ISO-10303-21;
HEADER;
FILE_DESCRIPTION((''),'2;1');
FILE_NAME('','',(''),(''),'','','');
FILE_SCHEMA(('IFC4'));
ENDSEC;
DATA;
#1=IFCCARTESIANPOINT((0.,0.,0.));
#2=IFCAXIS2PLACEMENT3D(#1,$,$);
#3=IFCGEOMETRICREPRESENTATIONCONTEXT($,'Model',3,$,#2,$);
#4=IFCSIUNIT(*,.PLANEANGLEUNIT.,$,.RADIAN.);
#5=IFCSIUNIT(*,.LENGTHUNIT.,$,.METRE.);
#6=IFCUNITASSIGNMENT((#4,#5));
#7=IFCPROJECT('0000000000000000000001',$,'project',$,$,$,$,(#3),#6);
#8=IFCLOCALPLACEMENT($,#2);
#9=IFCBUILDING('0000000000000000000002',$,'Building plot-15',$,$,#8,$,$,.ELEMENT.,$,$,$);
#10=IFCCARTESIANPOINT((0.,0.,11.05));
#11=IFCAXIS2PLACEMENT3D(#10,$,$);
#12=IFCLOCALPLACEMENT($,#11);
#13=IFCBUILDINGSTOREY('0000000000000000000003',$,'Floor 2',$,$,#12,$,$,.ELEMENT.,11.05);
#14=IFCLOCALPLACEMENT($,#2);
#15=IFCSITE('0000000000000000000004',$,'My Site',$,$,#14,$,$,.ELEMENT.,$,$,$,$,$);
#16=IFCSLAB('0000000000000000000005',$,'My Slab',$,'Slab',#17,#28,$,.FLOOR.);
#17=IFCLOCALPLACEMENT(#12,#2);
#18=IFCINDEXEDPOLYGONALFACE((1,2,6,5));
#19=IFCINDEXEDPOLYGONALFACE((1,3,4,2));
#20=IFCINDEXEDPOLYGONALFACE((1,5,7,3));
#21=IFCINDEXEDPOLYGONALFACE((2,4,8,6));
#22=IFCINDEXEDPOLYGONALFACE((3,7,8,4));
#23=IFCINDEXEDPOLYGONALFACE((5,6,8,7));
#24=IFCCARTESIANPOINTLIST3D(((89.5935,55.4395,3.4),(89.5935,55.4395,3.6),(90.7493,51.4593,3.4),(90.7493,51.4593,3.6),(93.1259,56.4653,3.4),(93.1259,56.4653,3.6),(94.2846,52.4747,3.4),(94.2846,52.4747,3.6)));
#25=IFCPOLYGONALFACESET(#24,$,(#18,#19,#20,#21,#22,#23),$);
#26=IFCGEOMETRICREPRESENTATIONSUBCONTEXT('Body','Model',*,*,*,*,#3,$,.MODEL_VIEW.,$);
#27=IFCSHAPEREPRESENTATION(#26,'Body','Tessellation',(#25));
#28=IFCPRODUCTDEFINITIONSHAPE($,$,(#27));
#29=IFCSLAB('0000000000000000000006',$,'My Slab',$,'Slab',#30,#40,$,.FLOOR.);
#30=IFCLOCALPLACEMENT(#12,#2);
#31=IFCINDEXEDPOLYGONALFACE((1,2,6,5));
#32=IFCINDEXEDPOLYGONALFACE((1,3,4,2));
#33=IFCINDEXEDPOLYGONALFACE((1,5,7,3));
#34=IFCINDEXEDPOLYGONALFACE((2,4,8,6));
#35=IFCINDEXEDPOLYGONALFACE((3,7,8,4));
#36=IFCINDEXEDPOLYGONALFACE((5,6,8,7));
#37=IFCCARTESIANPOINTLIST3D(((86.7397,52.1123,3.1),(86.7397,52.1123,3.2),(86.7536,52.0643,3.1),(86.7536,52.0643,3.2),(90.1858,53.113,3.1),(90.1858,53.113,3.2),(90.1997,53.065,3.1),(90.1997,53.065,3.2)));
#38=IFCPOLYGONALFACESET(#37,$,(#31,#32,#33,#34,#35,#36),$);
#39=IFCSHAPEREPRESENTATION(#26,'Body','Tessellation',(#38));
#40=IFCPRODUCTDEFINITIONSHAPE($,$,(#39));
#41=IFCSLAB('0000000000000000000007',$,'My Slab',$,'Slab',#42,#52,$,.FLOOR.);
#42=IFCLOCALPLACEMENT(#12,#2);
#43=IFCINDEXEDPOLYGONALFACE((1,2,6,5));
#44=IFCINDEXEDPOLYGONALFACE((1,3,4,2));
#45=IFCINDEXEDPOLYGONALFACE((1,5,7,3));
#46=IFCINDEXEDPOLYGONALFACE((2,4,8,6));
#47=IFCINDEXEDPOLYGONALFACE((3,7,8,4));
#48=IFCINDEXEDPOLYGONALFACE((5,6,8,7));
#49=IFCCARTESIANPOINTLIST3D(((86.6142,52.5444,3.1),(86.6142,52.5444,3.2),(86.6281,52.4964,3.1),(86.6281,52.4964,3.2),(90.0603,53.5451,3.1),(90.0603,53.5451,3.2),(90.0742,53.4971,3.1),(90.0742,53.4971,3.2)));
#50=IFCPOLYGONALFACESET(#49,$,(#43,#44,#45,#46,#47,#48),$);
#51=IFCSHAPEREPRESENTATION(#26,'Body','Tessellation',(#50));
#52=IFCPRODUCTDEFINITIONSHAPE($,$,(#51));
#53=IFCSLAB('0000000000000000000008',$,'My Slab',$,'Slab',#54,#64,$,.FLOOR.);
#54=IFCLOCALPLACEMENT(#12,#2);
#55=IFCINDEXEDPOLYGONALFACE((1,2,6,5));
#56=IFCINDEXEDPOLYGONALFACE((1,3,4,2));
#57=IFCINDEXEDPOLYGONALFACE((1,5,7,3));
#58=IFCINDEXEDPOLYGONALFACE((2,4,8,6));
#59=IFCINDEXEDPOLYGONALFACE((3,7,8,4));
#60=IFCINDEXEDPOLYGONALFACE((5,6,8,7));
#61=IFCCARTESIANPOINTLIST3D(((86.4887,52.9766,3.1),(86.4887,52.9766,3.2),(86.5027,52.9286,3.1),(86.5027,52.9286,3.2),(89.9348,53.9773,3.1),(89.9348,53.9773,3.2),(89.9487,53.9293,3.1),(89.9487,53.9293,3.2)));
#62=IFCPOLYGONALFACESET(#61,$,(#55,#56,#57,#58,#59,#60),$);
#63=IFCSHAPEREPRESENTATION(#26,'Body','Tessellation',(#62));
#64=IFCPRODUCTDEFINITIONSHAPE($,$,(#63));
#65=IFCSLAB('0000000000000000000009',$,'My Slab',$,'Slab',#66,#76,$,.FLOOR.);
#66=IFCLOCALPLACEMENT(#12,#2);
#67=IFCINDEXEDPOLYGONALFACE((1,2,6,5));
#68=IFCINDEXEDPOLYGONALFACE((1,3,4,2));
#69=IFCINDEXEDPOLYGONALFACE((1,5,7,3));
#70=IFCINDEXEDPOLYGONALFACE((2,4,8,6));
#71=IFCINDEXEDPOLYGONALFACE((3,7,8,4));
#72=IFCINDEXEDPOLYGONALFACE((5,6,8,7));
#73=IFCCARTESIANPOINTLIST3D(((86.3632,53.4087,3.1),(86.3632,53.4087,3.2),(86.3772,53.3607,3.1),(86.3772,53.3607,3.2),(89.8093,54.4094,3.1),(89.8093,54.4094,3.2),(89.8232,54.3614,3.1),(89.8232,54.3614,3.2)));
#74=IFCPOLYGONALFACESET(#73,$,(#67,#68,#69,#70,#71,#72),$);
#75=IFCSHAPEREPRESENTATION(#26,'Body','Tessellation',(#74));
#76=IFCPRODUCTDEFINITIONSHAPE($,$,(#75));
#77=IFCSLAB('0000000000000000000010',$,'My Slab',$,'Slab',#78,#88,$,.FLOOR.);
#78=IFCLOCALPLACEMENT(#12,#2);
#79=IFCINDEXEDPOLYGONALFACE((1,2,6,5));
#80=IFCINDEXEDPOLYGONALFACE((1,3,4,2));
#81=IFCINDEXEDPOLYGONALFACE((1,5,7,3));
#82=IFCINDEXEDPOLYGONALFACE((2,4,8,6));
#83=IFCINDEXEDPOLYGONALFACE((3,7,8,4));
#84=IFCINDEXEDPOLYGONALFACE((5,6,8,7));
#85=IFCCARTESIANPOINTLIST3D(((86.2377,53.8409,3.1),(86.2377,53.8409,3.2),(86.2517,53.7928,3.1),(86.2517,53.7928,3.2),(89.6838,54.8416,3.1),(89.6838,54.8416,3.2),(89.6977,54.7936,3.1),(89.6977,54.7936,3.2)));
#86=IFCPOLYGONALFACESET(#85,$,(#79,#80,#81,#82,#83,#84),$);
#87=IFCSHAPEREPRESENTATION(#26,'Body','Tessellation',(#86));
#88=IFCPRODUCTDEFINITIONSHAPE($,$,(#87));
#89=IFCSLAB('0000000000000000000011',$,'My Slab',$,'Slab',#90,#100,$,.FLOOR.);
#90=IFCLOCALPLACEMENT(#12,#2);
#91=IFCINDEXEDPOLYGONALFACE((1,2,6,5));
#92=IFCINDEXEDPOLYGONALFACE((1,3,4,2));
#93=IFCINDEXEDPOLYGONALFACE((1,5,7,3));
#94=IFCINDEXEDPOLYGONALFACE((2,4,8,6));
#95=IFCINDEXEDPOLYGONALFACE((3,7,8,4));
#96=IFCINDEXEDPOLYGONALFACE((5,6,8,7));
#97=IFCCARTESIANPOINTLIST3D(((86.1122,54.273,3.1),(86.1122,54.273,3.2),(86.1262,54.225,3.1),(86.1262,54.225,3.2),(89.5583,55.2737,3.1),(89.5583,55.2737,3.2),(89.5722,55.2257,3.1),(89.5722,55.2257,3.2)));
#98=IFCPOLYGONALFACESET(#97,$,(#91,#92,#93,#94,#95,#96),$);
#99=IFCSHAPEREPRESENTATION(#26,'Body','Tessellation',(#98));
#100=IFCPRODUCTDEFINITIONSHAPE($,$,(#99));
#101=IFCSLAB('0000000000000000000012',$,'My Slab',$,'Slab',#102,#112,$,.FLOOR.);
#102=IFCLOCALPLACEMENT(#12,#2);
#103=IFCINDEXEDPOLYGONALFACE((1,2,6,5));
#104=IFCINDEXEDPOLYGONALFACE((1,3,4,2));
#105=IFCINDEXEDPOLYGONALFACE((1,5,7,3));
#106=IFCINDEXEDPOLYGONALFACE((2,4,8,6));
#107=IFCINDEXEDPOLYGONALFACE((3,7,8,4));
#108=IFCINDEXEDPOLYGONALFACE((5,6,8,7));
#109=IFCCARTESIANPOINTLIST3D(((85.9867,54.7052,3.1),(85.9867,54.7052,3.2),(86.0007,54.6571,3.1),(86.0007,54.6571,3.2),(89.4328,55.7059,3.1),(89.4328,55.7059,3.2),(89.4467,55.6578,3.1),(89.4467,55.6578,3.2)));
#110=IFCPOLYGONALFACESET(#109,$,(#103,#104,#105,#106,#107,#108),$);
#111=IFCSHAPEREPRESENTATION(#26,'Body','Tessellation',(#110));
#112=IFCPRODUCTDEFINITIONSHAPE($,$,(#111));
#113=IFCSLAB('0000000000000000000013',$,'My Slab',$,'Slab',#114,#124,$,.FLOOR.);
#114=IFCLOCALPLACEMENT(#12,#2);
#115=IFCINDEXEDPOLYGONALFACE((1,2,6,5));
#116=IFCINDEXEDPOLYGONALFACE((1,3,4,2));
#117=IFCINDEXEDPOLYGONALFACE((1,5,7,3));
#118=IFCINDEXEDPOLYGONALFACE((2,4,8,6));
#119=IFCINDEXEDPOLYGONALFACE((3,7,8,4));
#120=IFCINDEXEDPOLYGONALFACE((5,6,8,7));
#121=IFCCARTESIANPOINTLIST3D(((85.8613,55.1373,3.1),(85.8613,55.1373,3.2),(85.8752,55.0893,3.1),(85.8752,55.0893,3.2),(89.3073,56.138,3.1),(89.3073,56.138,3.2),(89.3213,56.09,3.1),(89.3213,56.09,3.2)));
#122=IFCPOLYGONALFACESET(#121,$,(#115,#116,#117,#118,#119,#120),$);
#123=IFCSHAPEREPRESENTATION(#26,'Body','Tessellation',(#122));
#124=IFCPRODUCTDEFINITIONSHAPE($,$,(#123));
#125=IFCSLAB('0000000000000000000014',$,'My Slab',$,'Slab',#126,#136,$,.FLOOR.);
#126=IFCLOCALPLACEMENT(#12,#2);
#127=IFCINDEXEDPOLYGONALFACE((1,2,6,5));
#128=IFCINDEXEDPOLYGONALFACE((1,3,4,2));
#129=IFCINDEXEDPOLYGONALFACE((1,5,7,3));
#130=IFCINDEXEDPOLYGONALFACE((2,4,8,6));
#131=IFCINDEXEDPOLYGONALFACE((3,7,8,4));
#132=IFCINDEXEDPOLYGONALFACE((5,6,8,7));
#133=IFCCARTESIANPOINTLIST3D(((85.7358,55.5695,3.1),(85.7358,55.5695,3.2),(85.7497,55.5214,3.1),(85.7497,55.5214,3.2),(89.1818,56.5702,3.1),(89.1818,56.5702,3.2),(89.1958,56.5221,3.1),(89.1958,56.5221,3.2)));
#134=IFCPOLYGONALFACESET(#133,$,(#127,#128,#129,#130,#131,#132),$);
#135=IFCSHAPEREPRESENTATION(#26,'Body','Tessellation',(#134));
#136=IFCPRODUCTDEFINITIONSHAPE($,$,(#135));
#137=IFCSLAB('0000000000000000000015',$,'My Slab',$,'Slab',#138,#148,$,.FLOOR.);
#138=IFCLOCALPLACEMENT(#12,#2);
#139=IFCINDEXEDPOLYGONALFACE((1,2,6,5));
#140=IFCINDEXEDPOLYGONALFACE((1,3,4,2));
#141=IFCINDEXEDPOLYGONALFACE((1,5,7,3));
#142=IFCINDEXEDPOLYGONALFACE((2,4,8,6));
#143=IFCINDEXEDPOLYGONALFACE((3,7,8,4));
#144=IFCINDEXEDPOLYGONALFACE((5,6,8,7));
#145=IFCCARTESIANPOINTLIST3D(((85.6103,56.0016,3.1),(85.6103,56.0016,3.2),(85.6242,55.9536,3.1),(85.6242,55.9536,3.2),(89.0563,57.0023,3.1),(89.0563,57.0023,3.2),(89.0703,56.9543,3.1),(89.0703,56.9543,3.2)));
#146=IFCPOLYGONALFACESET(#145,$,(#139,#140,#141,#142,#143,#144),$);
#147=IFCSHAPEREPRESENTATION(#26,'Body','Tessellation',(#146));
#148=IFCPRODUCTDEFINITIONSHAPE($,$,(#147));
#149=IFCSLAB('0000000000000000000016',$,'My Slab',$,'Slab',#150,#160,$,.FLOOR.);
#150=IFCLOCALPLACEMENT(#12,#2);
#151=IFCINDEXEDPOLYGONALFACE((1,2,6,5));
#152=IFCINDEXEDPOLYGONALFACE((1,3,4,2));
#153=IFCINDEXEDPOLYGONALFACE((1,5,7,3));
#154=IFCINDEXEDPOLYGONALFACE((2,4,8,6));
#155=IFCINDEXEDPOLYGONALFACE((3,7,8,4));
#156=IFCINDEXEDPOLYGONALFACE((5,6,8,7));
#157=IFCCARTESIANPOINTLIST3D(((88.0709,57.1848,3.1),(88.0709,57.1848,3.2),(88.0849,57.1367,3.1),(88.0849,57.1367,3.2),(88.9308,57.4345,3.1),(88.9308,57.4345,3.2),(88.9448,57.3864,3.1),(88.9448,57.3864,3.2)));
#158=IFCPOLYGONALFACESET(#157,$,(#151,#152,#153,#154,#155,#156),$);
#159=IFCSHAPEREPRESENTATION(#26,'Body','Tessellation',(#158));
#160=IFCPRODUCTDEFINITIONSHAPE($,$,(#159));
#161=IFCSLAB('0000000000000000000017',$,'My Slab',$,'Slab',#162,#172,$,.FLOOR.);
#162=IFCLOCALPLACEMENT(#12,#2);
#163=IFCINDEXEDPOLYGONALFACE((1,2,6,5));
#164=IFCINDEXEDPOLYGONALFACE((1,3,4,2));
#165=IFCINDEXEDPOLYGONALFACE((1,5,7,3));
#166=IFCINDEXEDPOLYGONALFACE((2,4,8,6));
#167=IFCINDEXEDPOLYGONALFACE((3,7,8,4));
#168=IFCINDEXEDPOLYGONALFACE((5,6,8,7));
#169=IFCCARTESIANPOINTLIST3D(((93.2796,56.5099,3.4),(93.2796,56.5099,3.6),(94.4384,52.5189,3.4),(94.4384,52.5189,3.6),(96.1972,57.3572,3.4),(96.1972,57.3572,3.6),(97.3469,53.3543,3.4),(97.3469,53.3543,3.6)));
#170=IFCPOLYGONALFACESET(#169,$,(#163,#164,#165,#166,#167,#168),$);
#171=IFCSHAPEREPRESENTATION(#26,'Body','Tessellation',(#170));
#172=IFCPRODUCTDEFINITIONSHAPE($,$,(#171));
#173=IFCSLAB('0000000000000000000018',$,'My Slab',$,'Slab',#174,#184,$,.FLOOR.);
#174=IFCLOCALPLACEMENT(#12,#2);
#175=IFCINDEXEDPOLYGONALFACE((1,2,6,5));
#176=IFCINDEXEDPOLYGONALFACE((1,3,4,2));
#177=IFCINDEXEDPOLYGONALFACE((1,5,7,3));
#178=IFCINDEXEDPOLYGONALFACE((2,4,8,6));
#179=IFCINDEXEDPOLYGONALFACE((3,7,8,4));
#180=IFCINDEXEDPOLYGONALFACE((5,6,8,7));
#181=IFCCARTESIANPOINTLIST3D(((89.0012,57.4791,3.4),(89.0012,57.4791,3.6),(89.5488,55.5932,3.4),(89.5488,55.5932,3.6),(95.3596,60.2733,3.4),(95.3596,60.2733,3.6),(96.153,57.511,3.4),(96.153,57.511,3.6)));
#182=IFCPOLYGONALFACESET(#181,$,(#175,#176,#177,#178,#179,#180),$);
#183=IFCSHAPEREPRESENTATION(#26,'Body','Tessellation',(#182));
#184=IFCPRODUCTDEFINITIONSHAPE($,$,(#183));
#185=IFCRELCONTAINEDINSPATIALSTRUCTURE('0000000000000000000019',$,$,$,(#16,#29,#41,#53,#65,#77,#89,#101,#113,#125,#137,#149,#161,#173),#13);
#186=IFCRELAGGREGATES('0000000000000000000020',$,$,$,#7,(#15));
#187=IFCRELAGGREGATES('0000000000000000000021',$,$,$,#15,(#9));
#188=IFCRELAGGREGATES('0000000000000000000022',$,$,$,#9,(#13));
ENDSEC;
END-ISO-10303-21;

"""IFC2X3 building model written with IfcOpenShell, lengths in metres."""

from ifc_helpers import new_model, si_unit, frame, origin, place, context, subcontext, project, spatial, polyline, outline, extrude, element, save


model = new_model("IFC2X3")

# Units and contexts
model_context = context("Model", 3, world=origin())
body_context = subcontext(model_context, "Body", "Model", "MODEL_VIEW")
ifc_project = project(units=[si_unit("PLANEANGLEUNIT", "RADIAN"), si_unit("LENGTHUNIT", "METRE")], contexts=[model_context])

# Site, building, storey
site_placement = place(None, origin())
site = spatial("IfcSite", under=ifc_project, at=site_placement, Name="My Site", CompositionType="ELEMENT")
building_placement = place(None, origin())
building = spatial("IfcBuilding", under=site, at=building_placement, Name="Building plot-15", CompositionType="ELEMENT")
storey_placement = place(None, frame((0.0, 0.0, 11.05)))
storey = spatial("IfcBuildingStorey", under=building, at=storey_placement, Name="Floor 2", CompositionType="ELEMENT", Elevation=11.05)

# Slabs
slab_1_placement = place(storey_placement, frame((0.0, 0.0, 3.4)))
element("IfcSlab", 1, at=slab_1_placement, inside=storey, Name="My Slab", ObjectType="Slab", PredefinedType="FLOOR", context=body_context, shape_type="SweptSolid", body=[
    extrude(outline(polyline([(93.1259, 56.4653), (89.5935, 55.4395), (90.7493, 51.4593), (94.2846, 52.4747), (93.1259, 56.4653)])), origin(), (0.0, 0.0, 1.0), 0.2),
])
slab_2_placement = place(storey_placement, frame((0.0, 0.0, 3.1)))
element("IfcSlab", 2, at=slab_2_placement, inside=storey, Name="My Slab", ObjectType="Slab", PredefinedType="FLOOR", context=body_context, shape_type="SweptSolid", body=[
    extrude(outline(polyline([(90.1997, 53.065), (90.1858, 53.113), (86.7397, 52.1123), (86.7536, 52.0643), (90.1997, 53.065)])), origin(), (0.0, 0.0, 1.0), 0.1),
])
slab_3_placement = place(storey_placement, frame((0.0, 0.0, 3.1)))
element("IfcSlab", 3, at=slab_3_placement, inside=storey, Name="My Slab", ObjectType="Slab", PredefinedType="FLOOR", context=body_context, shape_type="SweptSolid", body=[
    extrude(outline(polyline([(90.0742, 53.4971), (90.0603, 53.5451), (86.6142, 52.5444), (86.6281, 52.4964), (90.0742, 53.4971)])), origin(), (0.0, 0.0, 1.0), 0.1),
])
slab_4_placement = place(storey_placement, frame((0.0, 0.0, 3.1)))
element("IfcSlab", 4, at=slab_4_placement, inside=storey, Name="My Slab", ObjectType="Slab", PredefinedType="FLOOR", context=body_context, shape_type="SweptSolid", body=[
    extrude(outline(polyline([(89.9487, 53.9293), (89.9348, 53.9773), (86.4887, 52.9766), (86.5027, 52.9286), (89.9487, 53.9293)])), origin(), (0.0, 0.0, 1.0), 0.1),
])
slab_5_placement = place(storey_placement, frame((0.0, 0.0, 3.1)))
element("IfcSlab", 5, at=slab_5_placement, inside=storey, Name="My Slab", ObjectType="Slab", PredefinedType="FLOOR", context=body_context, shape_type="SweptSolid", body=[
    extrude(outline(polyline([(89.8232, 54.3614), (89.8093, 54.4094), (86.3632, 53.4087), (86.3772, 53.3607), (89.8232, 54.3614)])), origin(), (0.0, 0.0, 1.0), 0.1),
])
slab_6_placement = place(storey_placement, frame((0.0, 0.0, 3.1)))
element("IfcSlab", 6, at=slab_6_placement, inside=storey, Name="My Slab", ObjectType="Slab", PredefinedType="FLOOR", context=body_context, shape_type="SweptSolid", body=[
    extrude(outline(polyline([(89.6977, 54.7936), (89.6838, 54.8416), (86.2377, 53.8409), (86.2517, 53.7928), (89.6977, 54.7936)])), origin(), (0.0, 0.0, 1.0), 0.1),
])
slab_7_placement = place(storey_placement, frame((0.0, 0.0, 3.1)))
element("IfcSlab", 7, at=slab_7_placement, inside=storey, Name="My Slab", ObjectType="Slab", PredefinedType="FLOOR", context=body_context, shape_type="SweptSolid", body=[
    extrude(outline(polyline([(89.5722, 55.2257), (89.5583, 55.2737), (86.1122, 54.273), (86.1262, 54.225), (89.5722, 55.2257)])), origin(), (0.0, 0.0, 1.0), 0.1),
])
slab_8_placement = place(storey_placement, frame((0.0, 0.0, 3.1)))
element("IfcSlab", 8, at=slab_8_placement, inside=storey, Name="My Slab", ObjectType="Slab", PredefinedType="FLOOR", context=body_context, shape_type="SweptSolid", body=[
    extrude(outline(polyline([(89.4467, 55.6578), (89.4328, 55.7059), (85.9867, 54.7052), (86.0007, 54.6571), (89.4467, 55.6578)])), origin(), (0.0, 0.0, 1.0), 0.1),
])
slab_9_placement = place(storey_placement, frame((0.0, 0.0, 3.1)))
element("IfcSlab", 9, at=slab_9_placement, inside=storey, Name="My Slab", ObjectType="Slab", PredefinedType="FLOOR", context=body_context, shape_type="SweptSolid", body=[
    extrude(outline(polyline([(89.3213, 56.09), (89.3073, 56.138), (85.8613, 55.1373), (85.8752, 55.0893), (89.3213, 56.09)])), origin(), (0.0, 0.0, 1.0), 0.1),
])
slab_10_placement = place(storey_placement, frame((0.0, 0.0, 3.1)))
element("IfcSlab", 10, at=slab_10_placement, inside=storey, Name="My Slab", ObjectType="Slab", PredefinedType="FLOOR", context=body_context, shape_type="SweptSolid", body=[
    extrude(outline(polyline([(89.1958, 56.5221), (89.1818, 56.5702), (85.7358, 55.5695), (85.7497, 55.5214), (89.1958, 56.5221)])), origin(), (0.0, 0.0, 1.0), 0.1),
])
slab_11_placement = place(storey_placement, frame((0.0, 0.0, 3.1)))
element("IfcSlab", 11, at=slab_11_placement, inside=storey, Name="My Slab", ObjectType="Slab", PredefinedType="FLOOR", context=body_context, shape_type="SweptSolid", body=[
    extrude(outline(polyline([(89.0703, 56.9543), (89.0563, 57.0023), (85.6103, 56.0016), (85.6242, 55.9536), (89.0703, 56.9543)])), origin(), (0.0, 0.0, 1.0), 0.1),
])
slab_12_placement = place(storey_placement, frame((0.0, 0.0, 3.1)))
element("IfcSlab", 12, at=slab_12_placement, inside=storey, Name="My Slab", ObjectType="Slab", PredefinedType="FLOOR", context=body_context, shape_type="SweptSolid", body=[
    extrude(outline(polyline([(88.9448, 57.3864), (88.9308, 57.4345), (88.0709, 57.1848), (88.0849, 57.1367), (88.9448, 57.3864)])), origin(), (0.0, 0.0, 1.0), 0.1),
])
slab_13_placement = place(storey_placement, frame((0.0, 0.0, 3.4)))
element("IfcSlab", 13, at=slab_13_placement, inside=storey, Name="My Slab", ObjectType="Slab", PredefinedType="FLOOR", context=body_context, shape_type="SweptSolid", body=[
    extrude(outline(polyline([(96.1972, 57.3572), (93.2796, 56.5099), (94.4384, 52.5189), (97.3469, 53.3543), (96.1972, 57.3572)])), origin(), (0.0, 0.0, 1.0), 0.2),
])
slab_14_placement = place(storey_placement, frame((0.0, 0.0, 3.4)))
element("IfcSlab", 14, at=slab_14_placement, inside=storey, Name="My Slab", ObjectType="Slab", PredefinedType="FLOOR", context=body_context, shape_type="SweptSolid", body=[
    extrude(outline(polyline([(89.0012, 57.4791), (89.5488, 55.5932), (96.153, 57.511), (95.3596, 60.2733), (89.0012, 57.4791)])), origin(), (0.0, 0.0, 1.0), 0.2),
])

save(model, "model.ifc")
